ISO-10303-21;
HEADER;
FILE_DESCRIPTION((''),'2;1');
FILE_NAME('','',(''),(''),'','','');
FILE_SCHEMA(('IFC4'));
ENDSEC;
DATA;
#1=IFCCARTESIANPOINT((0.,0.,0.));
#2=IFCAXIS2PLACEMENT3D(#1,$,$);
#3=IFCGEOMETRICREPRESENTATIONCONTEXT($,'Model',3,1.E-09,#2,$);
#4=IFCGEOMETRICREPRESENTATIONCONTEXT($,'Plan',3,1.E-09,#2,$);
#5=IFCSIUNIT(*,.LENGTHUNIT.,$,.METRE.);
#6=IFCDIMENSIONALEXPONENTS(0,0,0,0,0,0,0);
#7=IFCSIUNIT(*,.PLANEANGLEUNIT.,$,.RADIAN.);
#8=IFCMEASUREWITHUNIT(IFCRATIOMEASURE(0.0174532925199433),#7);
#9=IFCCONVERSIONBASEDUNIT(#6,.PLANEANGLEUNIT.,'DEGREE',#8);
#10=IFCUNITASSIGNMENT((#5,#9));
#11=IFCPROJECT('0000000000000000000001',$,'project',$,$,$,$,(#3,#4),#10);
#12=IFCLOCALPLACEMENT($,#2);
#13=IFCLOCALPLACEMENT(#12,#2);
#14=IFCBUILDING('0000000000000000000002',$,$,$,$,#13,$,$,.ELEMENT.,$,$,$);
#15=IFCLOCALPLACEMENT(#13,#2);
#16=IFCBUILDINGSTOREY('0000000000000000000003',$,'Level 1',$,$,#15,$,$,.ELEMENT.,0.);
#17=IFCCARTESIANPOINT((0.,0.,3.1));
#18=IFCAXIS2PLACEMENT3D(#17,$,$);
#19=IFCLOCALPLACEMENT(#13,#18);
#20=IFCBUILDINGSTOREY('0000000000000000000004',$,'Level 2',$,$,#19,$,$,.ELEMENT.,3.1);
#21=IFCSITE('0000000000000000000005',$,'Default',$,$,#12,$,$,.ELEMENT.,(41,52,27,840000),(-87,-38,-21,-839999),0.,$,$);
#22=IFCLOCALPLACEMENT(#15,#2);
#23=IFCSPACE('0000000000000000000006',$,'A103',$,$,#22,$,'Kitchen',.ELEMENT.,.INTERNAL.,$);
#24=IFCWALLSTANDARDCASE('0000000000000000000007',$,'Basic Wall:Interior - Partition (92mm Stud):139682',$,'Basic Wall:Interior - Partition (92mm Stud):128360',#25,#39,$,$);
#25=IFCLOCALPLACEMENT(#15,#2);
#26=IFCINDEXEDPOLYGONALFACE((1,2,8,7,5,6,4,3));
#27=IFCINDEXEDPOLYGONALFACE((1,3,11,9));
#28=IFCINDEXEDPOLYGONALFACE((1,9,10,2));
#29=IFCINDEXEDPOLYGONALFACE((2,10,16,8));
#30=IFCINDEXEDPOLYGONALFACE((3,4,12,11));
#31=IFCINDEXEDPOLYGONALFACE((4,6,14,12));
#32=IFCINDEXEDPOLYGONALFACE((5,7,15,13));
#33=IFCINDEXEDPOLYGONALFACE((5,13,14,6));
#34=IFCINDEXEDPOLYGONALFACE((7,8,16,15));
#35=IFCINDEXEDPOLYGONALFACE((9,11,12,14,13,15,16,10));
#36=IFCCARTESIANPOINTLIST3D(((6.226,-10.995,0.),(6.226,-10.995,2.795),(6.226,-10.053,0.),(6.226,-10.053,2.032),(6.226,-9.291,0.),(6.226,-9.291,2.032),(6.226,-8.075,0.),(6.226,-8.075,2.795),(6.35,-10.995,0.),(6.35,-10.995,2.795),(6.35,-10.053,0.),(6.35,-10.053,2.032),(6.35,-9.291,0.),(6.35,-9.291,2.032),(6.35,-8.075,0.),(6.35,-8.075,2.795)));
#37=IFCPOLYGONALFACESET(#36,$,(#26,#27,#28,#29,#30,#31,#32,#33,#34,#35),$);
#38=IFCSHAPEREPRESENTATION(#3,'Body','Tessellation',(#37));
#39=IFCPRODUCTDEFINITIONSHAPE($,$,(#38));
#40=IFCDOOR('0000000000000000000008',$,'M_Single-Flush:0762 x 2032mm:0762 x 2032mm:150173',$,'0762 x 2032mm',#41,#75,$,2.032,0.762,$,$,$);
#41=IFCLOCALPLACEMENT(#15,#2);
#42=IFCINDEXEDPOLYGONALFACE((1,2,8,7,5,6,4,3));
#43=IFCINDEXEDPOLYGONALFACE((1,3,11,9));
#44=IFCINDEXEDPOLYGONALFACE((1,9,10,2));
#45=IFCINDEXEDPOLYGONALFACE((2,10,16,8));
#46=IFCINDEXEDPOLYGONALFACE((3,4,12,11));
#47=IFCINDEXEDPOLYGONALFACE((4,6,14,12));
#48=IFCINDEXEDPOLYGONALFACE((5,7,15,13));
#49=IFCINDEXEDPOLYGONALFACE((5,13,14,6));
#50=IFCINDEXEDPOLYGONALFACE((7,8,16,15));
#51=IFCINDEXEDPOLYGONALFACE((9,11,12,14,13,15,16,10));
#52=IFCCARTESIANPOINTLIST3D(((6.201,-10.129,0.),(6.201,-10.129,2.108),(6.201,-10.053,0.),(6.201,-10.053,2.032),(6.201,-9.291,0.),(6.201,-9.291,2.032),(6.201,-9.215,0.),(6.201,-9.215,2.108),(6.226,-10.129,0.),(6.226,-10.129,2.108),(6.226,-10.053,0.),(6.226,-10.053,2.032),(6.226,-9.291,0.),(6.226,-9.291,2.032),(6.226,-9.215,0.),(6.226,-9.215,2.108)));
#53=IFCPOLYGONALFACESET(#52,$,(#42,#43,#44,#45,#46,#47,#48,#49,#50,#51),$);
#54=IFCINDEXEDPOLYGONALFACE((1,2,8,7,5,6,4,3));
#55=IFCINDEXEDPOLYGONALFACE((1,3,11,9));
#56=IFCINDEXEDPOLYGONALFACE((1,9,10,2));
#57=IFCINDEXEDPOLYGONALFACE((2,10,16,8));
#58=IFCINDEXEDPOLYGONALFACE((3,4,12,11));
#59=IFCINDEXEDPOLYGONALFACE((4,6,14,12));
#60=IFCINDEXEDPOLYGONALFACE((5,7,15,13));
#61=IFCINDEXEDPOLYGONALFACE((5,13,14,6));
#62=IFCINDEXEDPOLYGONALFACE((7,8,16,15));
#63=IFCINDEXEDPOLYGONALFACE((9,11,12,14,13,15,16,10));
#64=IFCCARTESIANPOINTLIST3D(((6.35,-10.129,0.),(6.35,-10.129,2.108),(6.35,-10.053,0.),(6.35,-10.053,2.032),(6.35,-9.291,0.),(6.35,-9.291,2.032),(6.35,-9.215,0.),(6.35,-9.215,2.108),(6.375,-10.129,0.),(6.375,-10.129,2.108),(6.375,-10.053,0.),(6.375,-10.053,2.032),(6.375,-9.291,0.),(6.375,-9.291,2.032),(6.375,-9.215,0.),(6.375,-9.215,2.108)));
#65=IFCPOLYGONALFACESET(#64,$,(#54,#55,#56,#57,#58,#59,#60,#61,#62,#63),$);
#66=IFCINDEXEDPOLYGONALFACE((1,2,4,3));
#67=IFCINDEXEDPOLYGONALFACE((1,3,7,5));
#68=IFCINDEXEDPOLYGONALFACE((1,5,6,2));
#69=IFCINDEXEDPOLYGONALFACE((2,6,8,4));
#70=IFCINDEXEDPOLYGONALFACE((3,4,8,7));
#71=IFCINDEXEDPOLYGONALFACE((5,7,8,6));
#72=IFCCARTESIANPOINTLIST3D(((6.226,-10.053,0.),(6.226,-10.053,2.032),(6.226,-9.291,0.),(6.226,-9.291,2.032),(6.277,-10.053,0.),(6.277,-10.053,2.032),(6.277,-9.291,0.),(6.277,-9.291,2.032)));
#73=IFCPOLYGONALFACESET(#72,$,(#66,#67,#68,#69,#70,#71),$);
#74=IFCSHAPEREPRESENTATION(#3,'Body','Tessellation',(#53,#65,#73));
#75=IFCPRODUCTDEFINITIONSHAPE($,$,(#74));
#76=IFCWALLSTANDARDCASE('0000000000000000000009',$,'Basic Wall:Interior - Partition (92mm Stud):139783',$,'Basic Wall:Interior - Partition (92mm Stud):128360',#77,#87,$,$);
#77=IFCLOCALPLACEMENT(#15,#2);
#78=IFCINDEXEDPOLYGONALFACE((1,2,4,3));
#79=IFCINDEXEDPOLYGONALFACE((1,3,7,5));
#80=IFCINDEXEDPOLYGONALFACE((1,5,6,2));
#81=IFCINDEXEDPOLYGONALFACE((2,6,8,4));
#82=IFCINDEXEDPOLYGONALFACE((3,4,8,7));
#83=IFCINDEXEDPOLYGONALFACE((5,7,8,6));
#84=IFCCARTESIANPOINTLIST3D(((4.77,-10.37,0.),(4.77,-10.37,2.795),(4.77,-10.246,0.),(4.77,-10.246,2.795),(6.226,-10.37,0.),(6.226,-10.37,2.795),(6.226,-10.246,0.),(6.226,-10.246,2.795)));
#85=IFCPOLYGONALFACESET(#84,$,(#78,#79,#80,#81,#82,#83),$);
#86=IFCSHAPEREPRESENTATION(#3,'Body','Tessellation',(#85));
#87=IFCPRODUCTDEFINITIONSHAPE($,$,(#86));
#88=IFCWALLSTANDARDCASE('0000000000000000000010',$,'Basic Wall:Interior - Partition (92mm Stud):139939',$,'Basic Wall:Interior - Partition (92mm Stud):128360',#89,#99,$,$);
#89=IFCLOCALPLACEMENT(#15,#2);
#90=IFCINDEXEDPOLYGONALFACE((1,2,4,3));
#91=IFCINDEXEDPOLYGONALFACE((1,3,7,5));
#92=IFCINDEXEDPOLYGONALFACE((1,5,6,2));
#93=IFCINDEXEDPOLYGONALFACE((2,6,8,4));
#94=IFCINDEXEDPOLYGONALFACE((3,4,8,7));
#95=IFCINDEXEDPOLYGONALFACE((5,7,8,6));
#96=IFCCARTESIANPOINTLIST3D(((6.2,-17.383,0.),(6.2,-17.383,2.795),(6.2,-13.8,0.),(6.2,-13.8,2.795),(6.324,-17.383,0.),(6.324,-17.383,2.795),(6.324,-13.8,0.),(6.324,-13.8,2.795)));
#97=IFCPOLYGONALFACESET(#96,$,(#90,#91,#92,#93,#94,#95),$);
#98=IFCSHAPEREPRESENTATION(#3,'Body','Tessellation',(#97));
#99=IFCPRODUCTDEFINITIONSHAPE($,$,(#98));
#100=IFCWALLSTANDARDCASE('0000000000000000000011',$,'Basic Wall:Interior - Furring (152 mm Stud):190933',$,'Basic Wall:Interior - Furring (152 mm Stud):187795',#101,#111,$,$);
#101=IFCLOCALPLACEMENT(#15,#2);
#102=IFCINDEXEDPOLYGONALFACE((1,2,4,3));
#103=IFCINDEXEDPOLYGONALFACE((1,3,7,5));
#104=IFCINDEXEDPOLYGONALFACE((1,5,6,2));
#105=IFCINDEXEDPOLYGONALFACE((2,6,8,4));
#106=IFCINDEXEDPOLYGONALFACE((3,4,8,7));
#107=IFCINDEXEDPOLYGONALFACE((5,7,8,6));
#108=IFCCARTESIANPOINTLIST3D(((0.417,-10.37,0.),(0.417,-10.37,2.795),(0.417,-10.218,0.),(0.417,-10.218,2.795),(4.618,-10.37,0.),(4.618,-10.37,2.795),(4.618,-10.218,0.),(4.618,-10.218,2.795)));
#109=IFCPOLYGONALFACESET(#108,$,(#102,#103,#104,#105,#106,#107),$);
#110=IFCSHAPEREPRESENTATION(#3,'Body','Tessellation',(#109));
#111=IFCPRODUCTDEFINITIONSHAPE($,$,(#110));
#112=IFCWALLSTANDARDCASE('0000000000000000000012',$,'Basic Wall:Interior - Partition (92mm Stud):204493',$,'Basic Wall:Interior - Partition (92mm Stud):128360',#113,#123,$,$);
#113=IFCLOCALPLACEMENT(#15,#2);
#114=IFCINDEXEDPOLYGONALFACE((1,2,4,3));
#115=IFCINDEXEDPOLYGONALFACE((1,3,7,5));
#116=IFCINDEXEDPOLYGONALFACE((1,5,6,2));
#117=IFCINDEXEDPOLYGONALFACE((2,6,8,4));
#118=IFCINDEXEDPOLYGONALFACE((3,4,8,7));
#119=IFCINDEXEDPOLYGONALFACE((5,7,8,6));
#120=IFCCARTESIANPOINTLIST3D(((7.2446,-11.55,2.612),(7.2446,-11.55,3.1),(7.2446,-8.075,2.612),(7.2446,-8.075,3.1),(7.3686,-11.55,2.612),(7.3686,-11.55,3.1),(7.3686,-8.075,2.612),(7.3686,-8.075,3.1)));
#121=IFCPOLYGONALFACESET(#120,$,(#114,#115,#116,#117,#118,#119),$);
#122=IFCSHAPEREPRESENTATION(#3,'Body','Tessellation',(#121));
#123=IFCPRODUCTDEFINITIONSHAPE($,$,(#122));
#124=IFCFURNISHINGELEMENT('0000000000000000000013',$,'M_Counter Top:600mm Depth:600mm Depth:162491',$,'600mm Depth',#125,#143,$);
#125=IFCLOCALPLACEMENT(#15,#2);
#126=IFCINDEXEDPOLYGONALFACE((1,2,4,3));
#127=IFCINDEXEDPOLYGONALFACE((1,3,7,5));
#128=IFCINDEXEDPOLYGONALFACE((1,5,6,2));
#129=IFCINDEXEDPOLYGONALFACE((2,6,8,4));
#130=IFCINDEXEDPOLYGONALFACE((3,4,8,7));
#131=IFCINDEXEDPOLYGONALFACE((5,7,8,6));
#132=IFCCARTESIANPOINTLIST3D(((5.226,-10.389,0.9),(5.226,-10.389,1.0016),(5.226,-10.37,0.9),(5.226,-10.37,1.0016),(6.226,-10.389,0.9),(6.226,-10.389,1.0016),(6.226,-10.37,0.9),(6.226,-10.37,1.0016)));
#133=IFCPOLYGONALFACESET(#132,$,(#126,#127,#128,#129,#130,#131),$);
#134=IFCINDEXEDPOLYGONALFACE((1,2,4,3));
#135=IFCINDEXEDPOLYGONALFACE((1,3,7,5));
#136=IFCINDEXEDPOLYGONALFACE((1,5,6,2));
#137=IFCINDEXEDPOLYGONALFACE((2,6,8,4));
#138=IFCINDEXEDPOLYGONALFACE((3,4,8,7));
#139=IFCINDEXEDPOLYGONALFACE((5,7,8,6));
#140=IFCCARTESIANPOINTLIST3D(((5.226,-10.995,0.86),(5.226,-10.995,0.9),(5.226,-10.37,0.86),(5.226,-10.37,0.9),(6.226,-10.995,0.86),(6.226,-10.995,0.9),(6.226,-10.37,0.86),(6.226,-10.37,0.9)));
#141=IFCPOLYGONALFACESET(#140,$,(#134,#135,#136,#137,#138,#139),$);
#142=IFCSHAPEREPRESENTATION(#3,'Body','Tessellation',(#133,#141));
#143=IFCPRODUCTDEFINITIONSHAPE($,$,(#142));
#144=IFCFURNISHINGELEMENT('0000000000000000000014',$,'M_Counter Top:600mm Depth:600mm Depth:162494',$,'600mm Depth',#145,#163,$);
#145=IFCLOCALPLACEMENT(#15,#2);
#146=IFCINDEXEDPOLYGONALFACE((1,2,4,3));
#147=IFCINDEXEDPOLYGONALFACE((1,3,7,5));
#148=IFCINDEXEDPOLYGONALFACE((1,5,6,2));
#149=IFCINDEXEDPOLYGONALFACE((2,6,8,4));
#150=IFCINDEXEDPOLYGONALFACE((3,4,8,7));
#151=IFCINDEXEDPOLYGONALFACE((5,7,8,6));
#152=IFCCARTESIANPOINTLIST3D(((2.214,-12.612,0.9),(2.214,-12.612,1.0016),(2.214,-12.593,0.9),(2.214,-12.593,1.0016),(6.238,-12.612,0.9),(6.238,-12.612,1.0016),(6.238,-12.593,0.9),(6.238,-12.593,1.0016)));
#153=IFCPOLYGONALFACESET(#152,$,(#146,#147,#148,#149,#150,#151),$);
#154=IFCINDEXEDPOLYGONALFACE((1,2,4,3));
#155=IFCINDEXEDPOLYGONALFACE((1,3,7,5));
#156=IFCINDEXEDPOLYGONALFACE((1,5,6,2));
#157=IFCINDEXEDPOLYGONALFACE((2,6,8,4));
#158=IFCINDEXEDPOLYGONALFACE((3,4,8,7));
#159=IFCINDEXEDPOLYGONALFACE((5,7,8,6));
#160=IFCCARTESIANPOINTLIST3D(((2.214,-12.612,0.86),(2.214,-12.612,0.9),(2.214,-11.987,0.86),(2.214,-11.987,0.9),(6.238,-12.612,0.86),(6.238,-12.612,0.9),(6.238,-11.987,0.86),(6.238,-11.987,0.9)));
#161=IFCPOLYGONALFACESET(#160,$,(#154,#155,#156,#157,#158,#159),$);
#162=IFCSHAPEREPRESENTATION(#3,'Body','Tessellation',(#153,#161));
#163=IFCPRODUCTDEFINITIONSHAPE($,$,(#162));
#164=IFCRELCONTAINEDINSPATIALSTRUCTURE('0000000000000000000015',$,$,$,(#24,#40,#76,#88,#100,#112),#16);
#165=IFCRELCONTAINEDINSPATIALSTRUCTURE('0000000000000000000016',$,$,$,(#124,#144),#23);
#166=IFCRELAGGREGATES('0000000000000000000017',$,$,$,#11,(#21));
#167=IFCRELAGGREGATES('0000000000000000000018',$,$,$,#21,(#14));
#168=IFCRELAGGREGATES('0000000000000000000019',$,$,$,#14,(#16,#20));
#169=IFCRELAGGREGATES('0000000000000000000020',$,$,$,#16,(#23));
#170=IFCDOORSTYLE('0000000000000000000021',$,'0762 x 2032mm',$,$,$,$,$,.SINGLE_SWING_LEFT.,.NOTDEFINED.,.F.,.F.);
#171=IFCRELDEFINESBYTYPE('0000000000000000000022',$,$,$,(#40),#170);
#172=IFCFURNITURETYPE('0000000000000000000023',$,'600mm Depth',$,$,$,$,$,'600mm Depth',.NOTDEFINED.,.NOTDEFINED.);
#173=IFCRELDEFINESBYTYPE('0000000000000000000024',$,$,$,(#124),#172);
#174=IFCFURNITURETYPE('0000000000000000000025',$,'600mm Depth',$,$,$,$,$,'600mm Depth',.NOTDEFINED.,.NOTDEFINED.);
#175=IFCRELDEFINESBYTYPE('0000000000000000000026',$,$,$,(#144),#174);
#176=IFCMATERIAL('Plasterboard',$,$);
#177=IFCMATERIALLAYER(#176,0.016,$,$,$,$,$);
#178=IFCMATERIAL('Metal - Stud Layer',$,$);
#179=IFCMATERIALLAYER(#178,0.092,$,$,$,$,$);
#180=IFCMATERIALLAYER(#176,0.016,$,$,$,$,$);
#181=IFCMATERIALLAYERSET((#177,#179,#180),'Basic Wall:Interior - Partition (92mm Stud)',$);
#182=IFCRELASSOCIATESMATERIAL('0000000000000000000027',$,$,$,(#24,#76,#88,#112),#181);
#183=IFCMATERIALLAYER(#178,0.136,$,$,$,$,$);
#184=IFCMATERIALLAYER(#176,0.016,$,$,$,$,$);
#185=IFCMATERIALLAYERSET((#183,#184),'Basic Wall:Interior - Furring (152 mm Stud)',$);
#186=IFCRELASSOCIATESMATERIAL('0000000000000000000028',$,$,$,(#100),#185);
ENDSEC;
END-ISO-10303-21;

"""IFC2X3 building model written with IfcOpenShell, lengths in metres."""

from ifc_helpers import new_model, entity, si_unit, converted_unit, frame, frame_2d, origin, origin_2d_with_axis, place, context, project, spatial, polyline, rectangle, outline, extrude, source, transform, mapped, material, layer, layer_set, layer_usage, type_object, type_shapes, element, fill, save


model = new_model("IFC2X3")

# Units and contexts
model_context = context("Model", 3, precision=1e-09, world=origin())
plan_context = context("Plan", 3, precision=1e-09, world=origin())
ifc_project = project(units=[si_unit("LENGTHUNIT", "METRE"), converted_unit("PLANEANGLEUNIT", "DEGREE", entity("IfcRatioMeasure", 0.0174532925199433), si_unit("PLANEANGLEUNIT", "RADIAN"), dimensions=[0, 0, 0, 0, 0, 0, 0])], contexts=[model_context, plan_context])

# Site, building, storey
site_placement = place(None, origin())
site = spatial("IfcSite", under=ifc_project, at=site_placement, Name="Default", CompositionType="ELEMENT", RefLatitude=(41, 52, 27, 840000), RefLongitude=(-87, -38, -21, -839999), RefElevation=0.0)
building_placement = place(site_placement, origin())
building = spatial("IfcBuilding", under=site, at=building_placement, CompositionType="ELEMENT")
storey_1_placement = place(building_placement, origin())
storey_1 = spatial("IfcBuildingStorey", under=building, at=storey_1_placement, Name="Level 1", CompositionType="ELEMENT", Elevation=0.0)

# Shared definitions
ifc_material_1 = material(Name="Metal - Stud Layer")
ifc_material_2 = material(Name="Plasterboard")

# Wall, opening, door
ifc_layer_1 = layer(ifc_material_2, 0.016)
ifc_layer_2 = layer(ifc_material_1, 0.092)
ifc_layer_3 = layer(ifc_material_2, 0.016)
ifc_layer_set_1 = layer_set([ifc_layer_1, ifc_layer_2, ifc_layer_3], Name="Basic Wall:Interior - Partition (92mm Stud)")
ifc_layer_usage_1 = layer_usage(ifc_layer_set_1, "AXIS2", "NEGATIVE", 0.062)
wall_1_placement = place(storey_1_placement, frame((6.288, -10.995, 0.0), z_axis=(0.0, 0.0, 1.0), x_axis=(0.0, 1.0, 0.0)))
wall_1 = element("IfcWallStandardCase", 1, at=wall_1_placement, inside=storey_1, material=ifc_layer_usage_1, Name="Basic Wall:Interior - Partition (92mm Stud):139682", ObjectType="Basic Wall:Interior - Partition (92mm Stud):128360", context=model_context, shape_type="SweptSolid", body=[
    extrude(rectangle(XDim=2.92, YDim=0.124, at=frame_2d((1.46, 0.0), x_axis=(-1.0, 0.0))), origin(), (0.0, 0.0, 1.0), 2.795),
])
opening_1_placement = place(wall_1_placement, frame((0.942, -0.062, 0.0)))
opening_1 = element("IfcOpeningElement", 2, at=opening_1_placement, cuts=wall_1, ObjectType="Opening", context=model_context, shape_type="SweptSolid", body=[
    extrude(rectangle(XDim=0.762, YDim=2.032, at=frame_2d((1.016, 0.381), x_axis=(0.0, -1.0))), frame((0.0, 0.0, 0.0), z_axis=(0.0, 1.0, 0.0), x_axis=(0.0, 0.0, 1.0)), (0.0, 0.0, 1.0), 0.124),
])
door_style_1 = type_object("IfcDoorStyle", Name="0762 x 2032mm", ConstructionType="NOTDEFINED", OperationType="SINGLE_SWING_LEFT", ParameterTakesPrecedence=False, Sizeable=False)
shared_shape_1 = source(origin(), model_context, "Body", "SweptSolid", [
    extrude(outline(polyline([(-0.457, -1.073), (0.457, -1.073), (0.457, 1.035), (0.381, 1.035), (0.381, -0.997), (-0.381, -0.997), (-0.381, 1.035), (-0.457, 1.035), (-0.457, -1.073)])), frame((0.381, 0.149, 1.035), z_axis=(0.0, -1.0, 0.0), x_axis=(-1.0, 0.0, 0.0)), (0.0, 0.0, 1.0), 0.025),
    extrude(outline(polyline([(-1.073, -0.457), (1.035, -0.457), (1.035, -0.381), (-0.997, -0.381), (-0.997, 0.381), (1.035, 0.381), (1.035, 0.457), (-1.073, 0.457), (-1.073, -0.457)])), frame((0.381, 0.0, 1.035), z_axis=(0.0, -1.0, 0.0), x_axis=(0.0, 0.0, -1.0)), (0.0, 0.0, 1.0), 0.025),
    extrude(rectangle(XDim=0.762, YDim=0.051, at=origin_2d_with_axis()), frame((0.381, 0.0985, 0.0)), (0.0, 0.0, 1.0), 2.032),
])
type_shapes(door_style_1, [shared_shape_1])
door_1_placement = place(opening_1_placement, origin())
door_1 = element("IfcDoor", 3, at=door_1_placement, inside=storey_1, type_object=door_style_1, Name="M_Single-Flush:0762 x 2032mm:0762 x 2032mm:150173", ObjectType="0762 x 2032mm", OverallHeight=2.032, OverallWidth=0.762, context=model_context, shape_type="MappedRepresentation", body=[
    mapped(shared_shape_1, transform((0.0, 0.0, 0.0), scale=1.0)),
])
fill(opening_1, door_1)

# Walls
ifc_layer_usage_2 = layer_usage(ifc_layer_set_1, "AXIS2", "NEGATIVE", 0.062)
wall_2_placement = place(storey_1_placement, frame((4.77, -10.308, 0.0)))
element("IfcWallStandardCase", 4, at=wall_2_placement, inside=storey_1, material=ifc_layer_usage_2, Name="Basic Wall:Interior - Partition (92mm Stud):139783", ObjectType="Basic Wall:Interior - Partition (92mm Stud):128360", context=model_context, shape_type="SweptSolid", body=[
    extrude(rectangle(XDim=1.456, YDim=0.124, at=frame_2d((0.728, 0.0), x_axis=(-1.0, 0.0))), origin(), (0.0, 0.0, 1.0), 2.795),
])
ifc_layer_usage_3 = layer_usage(ifc_layer_set_1, "AXIS2", "NEGATIVE", 0.062)
wall_3_placement = place(storey_1_placement, frame((6.262, -13.8, 0.0), z_axis=(0.0, 0.0, 1.0), x_axis=(0.0, -1.0, 0.0)))
element("IfcWallStandardCase", 5, at=wall_3_placement, inside=storey_1, material=ifc_layer_usage_3, Name="Basic Wall:Interior - Partition (92mm Stud):139939", ObjectType="Basic Wall:Interior - Partition (92mm Stud):128360", context=model_context, shape_type="SweptSolid", body=[
    extrude(rectangle(XDim=3.583, YDim=0.124, at=frame_2d((1.7915, 0.0), x_axis=(-1.0, 0.0))), origin(), (0.0, 0.0, 1.0), 2.795),
])

# Shared definitions
storey_2_placement = place(building_placement, frame((0.0, 0.0, 3.1)))
storey_2 = spatial("IfcBuildingStorey", under=building, at=storey_2_placement, Name="Level 2", CompositionType="ELEMENT", Elevation=3.1)

# Walls
ifc_layer_4 = layer(ifc_material_1, 0.136)
ifc_layer_5 = layer(ifc_material_2, 0.016)
ifc_layer_set_2 = layer_set([ifc_layer_4, ifc_layer_5], Name="Basic Wall:Interior - Furring (152 mm Stud)")
ifc_layer_usage_4 = layer_usage(ifc_layer_set_2, "AXIS2", "NEGATIVE", 0.076)
wall_4_placement = place(storey_1_placement, frame((0.417, -10.294, 0.0)))
element("IfcWallStandardCase", 6, at=wall_4_placement, inside=storey_1, material=ifc_layer_usage_4, Name="Basic Wall:Interior - Furring (152 mm Stud):190933", ObjectType="Basic Wall:Interior - Furring (152 mm Stud):187795", context=model_context, shape_type="SweptSolid", body=[
    extrude(rectangle(XDim=4.201, YDim=0.152, at=frame_2d((2.1005, 0.0), x_axis=(-1.0, 0.0))), origin(), (0.0, 0.0, 1.0), 2.795),
])
ifc_layer_usage_5 = layer_usage(ifc_layer_set_1, "AXIS2", "NEGATIVE", 0.062)
wall_5_placement = place(storey_1_placement, frame((7.3066, -11.55, 2.612), z_axis=(0.0, 0.0, 1.0), x_axis=(0.0, 1.0, 0.0)))
element("IfcWallStandardCase", 7, at=wall_5_placement, inside=storey_1, material=ifc_layer_usage_5, Name="Basic Wall:Interior - Partition (92mm Stud):204493", ObjectType="Basic Wall:Interior - Partition (92mm Stud):128360", context=model_context, shape_type="SweptSolid", body=[
    extrude(rectangle(XDim=3.475, YDim=0.124, at=frame_2d((1.7375, 0.0), x_axis=(-1.0, 0.0))), origin(), (0.0, 0.0, 1.0), 0.488),
])

# Shared definitions
space_1_placement = place(storey_1_placement, origin())
space_1 = spatial("IfcSpace", under=storey_1, at=space_1_placement, Name="A103", LongName="Kitchen", CompositionType="ELEMENT", InteriorOrExteriorSpace="INTERNAL")

# Furnishing elements
furniture_type_1 = type_object("IfcFurnitureType", Name="600mm Depth", ElementType="600mm Depth", AssemblyPlace="NOTDEFINED")
shared_shape_2 = source(origin(), model_context, "Body", "SweptSolid", [
    extrude(rectangle(XDim=0.0191, YDim=1.0, at=origin_2d_with_axis()), frame((-0.7005, -0.0095, 0.9), z_axis=(0.0, 0.0, 1.0), x_axis=(0.0, -1.0, 0.0)), (0.0, 0.0, 1.0), 0.1016),
    extrude(rectangle(XDim=1.0, YDim=0.625, at=origin_2d_with_axis()), frame((-0.7005, -0.3125, 0.86), z_axis=(0.0, 0.0, 1.0), x_axis=(-1.0, 0.0, 0.0)), (0.0, 0.0, 1.0), 0.04),
])
type_shapes(furniture_type_1, [shared_shape_2])
furnishing_1_placement = place(space_1_placement, frame((6.4265, -10.37, 0.0)))
element("IfcFurnishingElement", 8, at=furnishing_1_placement, inside=space_1, type_object=furniture_type_1, Name="M_Counter Top:600mm Depth:600mm Depth:162491", ObjectType="600mm Depth", context=model_context, shape_type="MappedRepresentation", body=[
    mapped(shared_shape_2, transform((0.0, 0.0, 0.0), scale=1.0)),
])
furniture_type_2 = type_object("IfcFurnitureType", Name="600mm Depth", ElementType="600mm Depth", AssemblyPlace="NOTDEFINED")
shared_shape_3 = source(origin(), model_context, "Body", "SweptSolid", [
    extrude(rectangle(XDim=0.0191, YDim=4.024, at=origin_2d_with_axis()), frame((0.8115, -0.0095, 0.9), z_axis=(0.0, 0.0, 1.0), x_axis=(0.0, -1.0, 0.0)), (0.0, 0.0, 1.0), 0.1016),
    extrude(rectangle(XDim=4.024, YDim=0.625, at=origin_2d_with_axis()), frame((0.8115, -0.3125, 0.86), z_axis=(0.0, 0.0, 1.0), x_axis=(-1.0, 0.0, 0.0)), (0.0, 0.0, 1.0), 0.04),
])
type_shapes(furniture_type_2, [shared_shape_3])
furnishing_2_placement = place(space_1_placement, frame((5.0375, -12.612, 0.0), z_axis=(0.0, 0.0, 1.0), x_axis=(-1.0, 0.0, 0.0)))
element("IfcFurnishingElement", 9, at=furnishing_2_placement, inside=space_1, type_object=furniture_type_2, Name="M_Counter Top:600mm Depth:600mm Depth:162494", ObjectType="600mm Depth", context=model_context, shape_type="MappedRepresentation", body=[
    mapped(shared_shape_3, transform((0.0, 0.0, 0.0), scale=1.0)),
])

save(model, "model.ifc")
